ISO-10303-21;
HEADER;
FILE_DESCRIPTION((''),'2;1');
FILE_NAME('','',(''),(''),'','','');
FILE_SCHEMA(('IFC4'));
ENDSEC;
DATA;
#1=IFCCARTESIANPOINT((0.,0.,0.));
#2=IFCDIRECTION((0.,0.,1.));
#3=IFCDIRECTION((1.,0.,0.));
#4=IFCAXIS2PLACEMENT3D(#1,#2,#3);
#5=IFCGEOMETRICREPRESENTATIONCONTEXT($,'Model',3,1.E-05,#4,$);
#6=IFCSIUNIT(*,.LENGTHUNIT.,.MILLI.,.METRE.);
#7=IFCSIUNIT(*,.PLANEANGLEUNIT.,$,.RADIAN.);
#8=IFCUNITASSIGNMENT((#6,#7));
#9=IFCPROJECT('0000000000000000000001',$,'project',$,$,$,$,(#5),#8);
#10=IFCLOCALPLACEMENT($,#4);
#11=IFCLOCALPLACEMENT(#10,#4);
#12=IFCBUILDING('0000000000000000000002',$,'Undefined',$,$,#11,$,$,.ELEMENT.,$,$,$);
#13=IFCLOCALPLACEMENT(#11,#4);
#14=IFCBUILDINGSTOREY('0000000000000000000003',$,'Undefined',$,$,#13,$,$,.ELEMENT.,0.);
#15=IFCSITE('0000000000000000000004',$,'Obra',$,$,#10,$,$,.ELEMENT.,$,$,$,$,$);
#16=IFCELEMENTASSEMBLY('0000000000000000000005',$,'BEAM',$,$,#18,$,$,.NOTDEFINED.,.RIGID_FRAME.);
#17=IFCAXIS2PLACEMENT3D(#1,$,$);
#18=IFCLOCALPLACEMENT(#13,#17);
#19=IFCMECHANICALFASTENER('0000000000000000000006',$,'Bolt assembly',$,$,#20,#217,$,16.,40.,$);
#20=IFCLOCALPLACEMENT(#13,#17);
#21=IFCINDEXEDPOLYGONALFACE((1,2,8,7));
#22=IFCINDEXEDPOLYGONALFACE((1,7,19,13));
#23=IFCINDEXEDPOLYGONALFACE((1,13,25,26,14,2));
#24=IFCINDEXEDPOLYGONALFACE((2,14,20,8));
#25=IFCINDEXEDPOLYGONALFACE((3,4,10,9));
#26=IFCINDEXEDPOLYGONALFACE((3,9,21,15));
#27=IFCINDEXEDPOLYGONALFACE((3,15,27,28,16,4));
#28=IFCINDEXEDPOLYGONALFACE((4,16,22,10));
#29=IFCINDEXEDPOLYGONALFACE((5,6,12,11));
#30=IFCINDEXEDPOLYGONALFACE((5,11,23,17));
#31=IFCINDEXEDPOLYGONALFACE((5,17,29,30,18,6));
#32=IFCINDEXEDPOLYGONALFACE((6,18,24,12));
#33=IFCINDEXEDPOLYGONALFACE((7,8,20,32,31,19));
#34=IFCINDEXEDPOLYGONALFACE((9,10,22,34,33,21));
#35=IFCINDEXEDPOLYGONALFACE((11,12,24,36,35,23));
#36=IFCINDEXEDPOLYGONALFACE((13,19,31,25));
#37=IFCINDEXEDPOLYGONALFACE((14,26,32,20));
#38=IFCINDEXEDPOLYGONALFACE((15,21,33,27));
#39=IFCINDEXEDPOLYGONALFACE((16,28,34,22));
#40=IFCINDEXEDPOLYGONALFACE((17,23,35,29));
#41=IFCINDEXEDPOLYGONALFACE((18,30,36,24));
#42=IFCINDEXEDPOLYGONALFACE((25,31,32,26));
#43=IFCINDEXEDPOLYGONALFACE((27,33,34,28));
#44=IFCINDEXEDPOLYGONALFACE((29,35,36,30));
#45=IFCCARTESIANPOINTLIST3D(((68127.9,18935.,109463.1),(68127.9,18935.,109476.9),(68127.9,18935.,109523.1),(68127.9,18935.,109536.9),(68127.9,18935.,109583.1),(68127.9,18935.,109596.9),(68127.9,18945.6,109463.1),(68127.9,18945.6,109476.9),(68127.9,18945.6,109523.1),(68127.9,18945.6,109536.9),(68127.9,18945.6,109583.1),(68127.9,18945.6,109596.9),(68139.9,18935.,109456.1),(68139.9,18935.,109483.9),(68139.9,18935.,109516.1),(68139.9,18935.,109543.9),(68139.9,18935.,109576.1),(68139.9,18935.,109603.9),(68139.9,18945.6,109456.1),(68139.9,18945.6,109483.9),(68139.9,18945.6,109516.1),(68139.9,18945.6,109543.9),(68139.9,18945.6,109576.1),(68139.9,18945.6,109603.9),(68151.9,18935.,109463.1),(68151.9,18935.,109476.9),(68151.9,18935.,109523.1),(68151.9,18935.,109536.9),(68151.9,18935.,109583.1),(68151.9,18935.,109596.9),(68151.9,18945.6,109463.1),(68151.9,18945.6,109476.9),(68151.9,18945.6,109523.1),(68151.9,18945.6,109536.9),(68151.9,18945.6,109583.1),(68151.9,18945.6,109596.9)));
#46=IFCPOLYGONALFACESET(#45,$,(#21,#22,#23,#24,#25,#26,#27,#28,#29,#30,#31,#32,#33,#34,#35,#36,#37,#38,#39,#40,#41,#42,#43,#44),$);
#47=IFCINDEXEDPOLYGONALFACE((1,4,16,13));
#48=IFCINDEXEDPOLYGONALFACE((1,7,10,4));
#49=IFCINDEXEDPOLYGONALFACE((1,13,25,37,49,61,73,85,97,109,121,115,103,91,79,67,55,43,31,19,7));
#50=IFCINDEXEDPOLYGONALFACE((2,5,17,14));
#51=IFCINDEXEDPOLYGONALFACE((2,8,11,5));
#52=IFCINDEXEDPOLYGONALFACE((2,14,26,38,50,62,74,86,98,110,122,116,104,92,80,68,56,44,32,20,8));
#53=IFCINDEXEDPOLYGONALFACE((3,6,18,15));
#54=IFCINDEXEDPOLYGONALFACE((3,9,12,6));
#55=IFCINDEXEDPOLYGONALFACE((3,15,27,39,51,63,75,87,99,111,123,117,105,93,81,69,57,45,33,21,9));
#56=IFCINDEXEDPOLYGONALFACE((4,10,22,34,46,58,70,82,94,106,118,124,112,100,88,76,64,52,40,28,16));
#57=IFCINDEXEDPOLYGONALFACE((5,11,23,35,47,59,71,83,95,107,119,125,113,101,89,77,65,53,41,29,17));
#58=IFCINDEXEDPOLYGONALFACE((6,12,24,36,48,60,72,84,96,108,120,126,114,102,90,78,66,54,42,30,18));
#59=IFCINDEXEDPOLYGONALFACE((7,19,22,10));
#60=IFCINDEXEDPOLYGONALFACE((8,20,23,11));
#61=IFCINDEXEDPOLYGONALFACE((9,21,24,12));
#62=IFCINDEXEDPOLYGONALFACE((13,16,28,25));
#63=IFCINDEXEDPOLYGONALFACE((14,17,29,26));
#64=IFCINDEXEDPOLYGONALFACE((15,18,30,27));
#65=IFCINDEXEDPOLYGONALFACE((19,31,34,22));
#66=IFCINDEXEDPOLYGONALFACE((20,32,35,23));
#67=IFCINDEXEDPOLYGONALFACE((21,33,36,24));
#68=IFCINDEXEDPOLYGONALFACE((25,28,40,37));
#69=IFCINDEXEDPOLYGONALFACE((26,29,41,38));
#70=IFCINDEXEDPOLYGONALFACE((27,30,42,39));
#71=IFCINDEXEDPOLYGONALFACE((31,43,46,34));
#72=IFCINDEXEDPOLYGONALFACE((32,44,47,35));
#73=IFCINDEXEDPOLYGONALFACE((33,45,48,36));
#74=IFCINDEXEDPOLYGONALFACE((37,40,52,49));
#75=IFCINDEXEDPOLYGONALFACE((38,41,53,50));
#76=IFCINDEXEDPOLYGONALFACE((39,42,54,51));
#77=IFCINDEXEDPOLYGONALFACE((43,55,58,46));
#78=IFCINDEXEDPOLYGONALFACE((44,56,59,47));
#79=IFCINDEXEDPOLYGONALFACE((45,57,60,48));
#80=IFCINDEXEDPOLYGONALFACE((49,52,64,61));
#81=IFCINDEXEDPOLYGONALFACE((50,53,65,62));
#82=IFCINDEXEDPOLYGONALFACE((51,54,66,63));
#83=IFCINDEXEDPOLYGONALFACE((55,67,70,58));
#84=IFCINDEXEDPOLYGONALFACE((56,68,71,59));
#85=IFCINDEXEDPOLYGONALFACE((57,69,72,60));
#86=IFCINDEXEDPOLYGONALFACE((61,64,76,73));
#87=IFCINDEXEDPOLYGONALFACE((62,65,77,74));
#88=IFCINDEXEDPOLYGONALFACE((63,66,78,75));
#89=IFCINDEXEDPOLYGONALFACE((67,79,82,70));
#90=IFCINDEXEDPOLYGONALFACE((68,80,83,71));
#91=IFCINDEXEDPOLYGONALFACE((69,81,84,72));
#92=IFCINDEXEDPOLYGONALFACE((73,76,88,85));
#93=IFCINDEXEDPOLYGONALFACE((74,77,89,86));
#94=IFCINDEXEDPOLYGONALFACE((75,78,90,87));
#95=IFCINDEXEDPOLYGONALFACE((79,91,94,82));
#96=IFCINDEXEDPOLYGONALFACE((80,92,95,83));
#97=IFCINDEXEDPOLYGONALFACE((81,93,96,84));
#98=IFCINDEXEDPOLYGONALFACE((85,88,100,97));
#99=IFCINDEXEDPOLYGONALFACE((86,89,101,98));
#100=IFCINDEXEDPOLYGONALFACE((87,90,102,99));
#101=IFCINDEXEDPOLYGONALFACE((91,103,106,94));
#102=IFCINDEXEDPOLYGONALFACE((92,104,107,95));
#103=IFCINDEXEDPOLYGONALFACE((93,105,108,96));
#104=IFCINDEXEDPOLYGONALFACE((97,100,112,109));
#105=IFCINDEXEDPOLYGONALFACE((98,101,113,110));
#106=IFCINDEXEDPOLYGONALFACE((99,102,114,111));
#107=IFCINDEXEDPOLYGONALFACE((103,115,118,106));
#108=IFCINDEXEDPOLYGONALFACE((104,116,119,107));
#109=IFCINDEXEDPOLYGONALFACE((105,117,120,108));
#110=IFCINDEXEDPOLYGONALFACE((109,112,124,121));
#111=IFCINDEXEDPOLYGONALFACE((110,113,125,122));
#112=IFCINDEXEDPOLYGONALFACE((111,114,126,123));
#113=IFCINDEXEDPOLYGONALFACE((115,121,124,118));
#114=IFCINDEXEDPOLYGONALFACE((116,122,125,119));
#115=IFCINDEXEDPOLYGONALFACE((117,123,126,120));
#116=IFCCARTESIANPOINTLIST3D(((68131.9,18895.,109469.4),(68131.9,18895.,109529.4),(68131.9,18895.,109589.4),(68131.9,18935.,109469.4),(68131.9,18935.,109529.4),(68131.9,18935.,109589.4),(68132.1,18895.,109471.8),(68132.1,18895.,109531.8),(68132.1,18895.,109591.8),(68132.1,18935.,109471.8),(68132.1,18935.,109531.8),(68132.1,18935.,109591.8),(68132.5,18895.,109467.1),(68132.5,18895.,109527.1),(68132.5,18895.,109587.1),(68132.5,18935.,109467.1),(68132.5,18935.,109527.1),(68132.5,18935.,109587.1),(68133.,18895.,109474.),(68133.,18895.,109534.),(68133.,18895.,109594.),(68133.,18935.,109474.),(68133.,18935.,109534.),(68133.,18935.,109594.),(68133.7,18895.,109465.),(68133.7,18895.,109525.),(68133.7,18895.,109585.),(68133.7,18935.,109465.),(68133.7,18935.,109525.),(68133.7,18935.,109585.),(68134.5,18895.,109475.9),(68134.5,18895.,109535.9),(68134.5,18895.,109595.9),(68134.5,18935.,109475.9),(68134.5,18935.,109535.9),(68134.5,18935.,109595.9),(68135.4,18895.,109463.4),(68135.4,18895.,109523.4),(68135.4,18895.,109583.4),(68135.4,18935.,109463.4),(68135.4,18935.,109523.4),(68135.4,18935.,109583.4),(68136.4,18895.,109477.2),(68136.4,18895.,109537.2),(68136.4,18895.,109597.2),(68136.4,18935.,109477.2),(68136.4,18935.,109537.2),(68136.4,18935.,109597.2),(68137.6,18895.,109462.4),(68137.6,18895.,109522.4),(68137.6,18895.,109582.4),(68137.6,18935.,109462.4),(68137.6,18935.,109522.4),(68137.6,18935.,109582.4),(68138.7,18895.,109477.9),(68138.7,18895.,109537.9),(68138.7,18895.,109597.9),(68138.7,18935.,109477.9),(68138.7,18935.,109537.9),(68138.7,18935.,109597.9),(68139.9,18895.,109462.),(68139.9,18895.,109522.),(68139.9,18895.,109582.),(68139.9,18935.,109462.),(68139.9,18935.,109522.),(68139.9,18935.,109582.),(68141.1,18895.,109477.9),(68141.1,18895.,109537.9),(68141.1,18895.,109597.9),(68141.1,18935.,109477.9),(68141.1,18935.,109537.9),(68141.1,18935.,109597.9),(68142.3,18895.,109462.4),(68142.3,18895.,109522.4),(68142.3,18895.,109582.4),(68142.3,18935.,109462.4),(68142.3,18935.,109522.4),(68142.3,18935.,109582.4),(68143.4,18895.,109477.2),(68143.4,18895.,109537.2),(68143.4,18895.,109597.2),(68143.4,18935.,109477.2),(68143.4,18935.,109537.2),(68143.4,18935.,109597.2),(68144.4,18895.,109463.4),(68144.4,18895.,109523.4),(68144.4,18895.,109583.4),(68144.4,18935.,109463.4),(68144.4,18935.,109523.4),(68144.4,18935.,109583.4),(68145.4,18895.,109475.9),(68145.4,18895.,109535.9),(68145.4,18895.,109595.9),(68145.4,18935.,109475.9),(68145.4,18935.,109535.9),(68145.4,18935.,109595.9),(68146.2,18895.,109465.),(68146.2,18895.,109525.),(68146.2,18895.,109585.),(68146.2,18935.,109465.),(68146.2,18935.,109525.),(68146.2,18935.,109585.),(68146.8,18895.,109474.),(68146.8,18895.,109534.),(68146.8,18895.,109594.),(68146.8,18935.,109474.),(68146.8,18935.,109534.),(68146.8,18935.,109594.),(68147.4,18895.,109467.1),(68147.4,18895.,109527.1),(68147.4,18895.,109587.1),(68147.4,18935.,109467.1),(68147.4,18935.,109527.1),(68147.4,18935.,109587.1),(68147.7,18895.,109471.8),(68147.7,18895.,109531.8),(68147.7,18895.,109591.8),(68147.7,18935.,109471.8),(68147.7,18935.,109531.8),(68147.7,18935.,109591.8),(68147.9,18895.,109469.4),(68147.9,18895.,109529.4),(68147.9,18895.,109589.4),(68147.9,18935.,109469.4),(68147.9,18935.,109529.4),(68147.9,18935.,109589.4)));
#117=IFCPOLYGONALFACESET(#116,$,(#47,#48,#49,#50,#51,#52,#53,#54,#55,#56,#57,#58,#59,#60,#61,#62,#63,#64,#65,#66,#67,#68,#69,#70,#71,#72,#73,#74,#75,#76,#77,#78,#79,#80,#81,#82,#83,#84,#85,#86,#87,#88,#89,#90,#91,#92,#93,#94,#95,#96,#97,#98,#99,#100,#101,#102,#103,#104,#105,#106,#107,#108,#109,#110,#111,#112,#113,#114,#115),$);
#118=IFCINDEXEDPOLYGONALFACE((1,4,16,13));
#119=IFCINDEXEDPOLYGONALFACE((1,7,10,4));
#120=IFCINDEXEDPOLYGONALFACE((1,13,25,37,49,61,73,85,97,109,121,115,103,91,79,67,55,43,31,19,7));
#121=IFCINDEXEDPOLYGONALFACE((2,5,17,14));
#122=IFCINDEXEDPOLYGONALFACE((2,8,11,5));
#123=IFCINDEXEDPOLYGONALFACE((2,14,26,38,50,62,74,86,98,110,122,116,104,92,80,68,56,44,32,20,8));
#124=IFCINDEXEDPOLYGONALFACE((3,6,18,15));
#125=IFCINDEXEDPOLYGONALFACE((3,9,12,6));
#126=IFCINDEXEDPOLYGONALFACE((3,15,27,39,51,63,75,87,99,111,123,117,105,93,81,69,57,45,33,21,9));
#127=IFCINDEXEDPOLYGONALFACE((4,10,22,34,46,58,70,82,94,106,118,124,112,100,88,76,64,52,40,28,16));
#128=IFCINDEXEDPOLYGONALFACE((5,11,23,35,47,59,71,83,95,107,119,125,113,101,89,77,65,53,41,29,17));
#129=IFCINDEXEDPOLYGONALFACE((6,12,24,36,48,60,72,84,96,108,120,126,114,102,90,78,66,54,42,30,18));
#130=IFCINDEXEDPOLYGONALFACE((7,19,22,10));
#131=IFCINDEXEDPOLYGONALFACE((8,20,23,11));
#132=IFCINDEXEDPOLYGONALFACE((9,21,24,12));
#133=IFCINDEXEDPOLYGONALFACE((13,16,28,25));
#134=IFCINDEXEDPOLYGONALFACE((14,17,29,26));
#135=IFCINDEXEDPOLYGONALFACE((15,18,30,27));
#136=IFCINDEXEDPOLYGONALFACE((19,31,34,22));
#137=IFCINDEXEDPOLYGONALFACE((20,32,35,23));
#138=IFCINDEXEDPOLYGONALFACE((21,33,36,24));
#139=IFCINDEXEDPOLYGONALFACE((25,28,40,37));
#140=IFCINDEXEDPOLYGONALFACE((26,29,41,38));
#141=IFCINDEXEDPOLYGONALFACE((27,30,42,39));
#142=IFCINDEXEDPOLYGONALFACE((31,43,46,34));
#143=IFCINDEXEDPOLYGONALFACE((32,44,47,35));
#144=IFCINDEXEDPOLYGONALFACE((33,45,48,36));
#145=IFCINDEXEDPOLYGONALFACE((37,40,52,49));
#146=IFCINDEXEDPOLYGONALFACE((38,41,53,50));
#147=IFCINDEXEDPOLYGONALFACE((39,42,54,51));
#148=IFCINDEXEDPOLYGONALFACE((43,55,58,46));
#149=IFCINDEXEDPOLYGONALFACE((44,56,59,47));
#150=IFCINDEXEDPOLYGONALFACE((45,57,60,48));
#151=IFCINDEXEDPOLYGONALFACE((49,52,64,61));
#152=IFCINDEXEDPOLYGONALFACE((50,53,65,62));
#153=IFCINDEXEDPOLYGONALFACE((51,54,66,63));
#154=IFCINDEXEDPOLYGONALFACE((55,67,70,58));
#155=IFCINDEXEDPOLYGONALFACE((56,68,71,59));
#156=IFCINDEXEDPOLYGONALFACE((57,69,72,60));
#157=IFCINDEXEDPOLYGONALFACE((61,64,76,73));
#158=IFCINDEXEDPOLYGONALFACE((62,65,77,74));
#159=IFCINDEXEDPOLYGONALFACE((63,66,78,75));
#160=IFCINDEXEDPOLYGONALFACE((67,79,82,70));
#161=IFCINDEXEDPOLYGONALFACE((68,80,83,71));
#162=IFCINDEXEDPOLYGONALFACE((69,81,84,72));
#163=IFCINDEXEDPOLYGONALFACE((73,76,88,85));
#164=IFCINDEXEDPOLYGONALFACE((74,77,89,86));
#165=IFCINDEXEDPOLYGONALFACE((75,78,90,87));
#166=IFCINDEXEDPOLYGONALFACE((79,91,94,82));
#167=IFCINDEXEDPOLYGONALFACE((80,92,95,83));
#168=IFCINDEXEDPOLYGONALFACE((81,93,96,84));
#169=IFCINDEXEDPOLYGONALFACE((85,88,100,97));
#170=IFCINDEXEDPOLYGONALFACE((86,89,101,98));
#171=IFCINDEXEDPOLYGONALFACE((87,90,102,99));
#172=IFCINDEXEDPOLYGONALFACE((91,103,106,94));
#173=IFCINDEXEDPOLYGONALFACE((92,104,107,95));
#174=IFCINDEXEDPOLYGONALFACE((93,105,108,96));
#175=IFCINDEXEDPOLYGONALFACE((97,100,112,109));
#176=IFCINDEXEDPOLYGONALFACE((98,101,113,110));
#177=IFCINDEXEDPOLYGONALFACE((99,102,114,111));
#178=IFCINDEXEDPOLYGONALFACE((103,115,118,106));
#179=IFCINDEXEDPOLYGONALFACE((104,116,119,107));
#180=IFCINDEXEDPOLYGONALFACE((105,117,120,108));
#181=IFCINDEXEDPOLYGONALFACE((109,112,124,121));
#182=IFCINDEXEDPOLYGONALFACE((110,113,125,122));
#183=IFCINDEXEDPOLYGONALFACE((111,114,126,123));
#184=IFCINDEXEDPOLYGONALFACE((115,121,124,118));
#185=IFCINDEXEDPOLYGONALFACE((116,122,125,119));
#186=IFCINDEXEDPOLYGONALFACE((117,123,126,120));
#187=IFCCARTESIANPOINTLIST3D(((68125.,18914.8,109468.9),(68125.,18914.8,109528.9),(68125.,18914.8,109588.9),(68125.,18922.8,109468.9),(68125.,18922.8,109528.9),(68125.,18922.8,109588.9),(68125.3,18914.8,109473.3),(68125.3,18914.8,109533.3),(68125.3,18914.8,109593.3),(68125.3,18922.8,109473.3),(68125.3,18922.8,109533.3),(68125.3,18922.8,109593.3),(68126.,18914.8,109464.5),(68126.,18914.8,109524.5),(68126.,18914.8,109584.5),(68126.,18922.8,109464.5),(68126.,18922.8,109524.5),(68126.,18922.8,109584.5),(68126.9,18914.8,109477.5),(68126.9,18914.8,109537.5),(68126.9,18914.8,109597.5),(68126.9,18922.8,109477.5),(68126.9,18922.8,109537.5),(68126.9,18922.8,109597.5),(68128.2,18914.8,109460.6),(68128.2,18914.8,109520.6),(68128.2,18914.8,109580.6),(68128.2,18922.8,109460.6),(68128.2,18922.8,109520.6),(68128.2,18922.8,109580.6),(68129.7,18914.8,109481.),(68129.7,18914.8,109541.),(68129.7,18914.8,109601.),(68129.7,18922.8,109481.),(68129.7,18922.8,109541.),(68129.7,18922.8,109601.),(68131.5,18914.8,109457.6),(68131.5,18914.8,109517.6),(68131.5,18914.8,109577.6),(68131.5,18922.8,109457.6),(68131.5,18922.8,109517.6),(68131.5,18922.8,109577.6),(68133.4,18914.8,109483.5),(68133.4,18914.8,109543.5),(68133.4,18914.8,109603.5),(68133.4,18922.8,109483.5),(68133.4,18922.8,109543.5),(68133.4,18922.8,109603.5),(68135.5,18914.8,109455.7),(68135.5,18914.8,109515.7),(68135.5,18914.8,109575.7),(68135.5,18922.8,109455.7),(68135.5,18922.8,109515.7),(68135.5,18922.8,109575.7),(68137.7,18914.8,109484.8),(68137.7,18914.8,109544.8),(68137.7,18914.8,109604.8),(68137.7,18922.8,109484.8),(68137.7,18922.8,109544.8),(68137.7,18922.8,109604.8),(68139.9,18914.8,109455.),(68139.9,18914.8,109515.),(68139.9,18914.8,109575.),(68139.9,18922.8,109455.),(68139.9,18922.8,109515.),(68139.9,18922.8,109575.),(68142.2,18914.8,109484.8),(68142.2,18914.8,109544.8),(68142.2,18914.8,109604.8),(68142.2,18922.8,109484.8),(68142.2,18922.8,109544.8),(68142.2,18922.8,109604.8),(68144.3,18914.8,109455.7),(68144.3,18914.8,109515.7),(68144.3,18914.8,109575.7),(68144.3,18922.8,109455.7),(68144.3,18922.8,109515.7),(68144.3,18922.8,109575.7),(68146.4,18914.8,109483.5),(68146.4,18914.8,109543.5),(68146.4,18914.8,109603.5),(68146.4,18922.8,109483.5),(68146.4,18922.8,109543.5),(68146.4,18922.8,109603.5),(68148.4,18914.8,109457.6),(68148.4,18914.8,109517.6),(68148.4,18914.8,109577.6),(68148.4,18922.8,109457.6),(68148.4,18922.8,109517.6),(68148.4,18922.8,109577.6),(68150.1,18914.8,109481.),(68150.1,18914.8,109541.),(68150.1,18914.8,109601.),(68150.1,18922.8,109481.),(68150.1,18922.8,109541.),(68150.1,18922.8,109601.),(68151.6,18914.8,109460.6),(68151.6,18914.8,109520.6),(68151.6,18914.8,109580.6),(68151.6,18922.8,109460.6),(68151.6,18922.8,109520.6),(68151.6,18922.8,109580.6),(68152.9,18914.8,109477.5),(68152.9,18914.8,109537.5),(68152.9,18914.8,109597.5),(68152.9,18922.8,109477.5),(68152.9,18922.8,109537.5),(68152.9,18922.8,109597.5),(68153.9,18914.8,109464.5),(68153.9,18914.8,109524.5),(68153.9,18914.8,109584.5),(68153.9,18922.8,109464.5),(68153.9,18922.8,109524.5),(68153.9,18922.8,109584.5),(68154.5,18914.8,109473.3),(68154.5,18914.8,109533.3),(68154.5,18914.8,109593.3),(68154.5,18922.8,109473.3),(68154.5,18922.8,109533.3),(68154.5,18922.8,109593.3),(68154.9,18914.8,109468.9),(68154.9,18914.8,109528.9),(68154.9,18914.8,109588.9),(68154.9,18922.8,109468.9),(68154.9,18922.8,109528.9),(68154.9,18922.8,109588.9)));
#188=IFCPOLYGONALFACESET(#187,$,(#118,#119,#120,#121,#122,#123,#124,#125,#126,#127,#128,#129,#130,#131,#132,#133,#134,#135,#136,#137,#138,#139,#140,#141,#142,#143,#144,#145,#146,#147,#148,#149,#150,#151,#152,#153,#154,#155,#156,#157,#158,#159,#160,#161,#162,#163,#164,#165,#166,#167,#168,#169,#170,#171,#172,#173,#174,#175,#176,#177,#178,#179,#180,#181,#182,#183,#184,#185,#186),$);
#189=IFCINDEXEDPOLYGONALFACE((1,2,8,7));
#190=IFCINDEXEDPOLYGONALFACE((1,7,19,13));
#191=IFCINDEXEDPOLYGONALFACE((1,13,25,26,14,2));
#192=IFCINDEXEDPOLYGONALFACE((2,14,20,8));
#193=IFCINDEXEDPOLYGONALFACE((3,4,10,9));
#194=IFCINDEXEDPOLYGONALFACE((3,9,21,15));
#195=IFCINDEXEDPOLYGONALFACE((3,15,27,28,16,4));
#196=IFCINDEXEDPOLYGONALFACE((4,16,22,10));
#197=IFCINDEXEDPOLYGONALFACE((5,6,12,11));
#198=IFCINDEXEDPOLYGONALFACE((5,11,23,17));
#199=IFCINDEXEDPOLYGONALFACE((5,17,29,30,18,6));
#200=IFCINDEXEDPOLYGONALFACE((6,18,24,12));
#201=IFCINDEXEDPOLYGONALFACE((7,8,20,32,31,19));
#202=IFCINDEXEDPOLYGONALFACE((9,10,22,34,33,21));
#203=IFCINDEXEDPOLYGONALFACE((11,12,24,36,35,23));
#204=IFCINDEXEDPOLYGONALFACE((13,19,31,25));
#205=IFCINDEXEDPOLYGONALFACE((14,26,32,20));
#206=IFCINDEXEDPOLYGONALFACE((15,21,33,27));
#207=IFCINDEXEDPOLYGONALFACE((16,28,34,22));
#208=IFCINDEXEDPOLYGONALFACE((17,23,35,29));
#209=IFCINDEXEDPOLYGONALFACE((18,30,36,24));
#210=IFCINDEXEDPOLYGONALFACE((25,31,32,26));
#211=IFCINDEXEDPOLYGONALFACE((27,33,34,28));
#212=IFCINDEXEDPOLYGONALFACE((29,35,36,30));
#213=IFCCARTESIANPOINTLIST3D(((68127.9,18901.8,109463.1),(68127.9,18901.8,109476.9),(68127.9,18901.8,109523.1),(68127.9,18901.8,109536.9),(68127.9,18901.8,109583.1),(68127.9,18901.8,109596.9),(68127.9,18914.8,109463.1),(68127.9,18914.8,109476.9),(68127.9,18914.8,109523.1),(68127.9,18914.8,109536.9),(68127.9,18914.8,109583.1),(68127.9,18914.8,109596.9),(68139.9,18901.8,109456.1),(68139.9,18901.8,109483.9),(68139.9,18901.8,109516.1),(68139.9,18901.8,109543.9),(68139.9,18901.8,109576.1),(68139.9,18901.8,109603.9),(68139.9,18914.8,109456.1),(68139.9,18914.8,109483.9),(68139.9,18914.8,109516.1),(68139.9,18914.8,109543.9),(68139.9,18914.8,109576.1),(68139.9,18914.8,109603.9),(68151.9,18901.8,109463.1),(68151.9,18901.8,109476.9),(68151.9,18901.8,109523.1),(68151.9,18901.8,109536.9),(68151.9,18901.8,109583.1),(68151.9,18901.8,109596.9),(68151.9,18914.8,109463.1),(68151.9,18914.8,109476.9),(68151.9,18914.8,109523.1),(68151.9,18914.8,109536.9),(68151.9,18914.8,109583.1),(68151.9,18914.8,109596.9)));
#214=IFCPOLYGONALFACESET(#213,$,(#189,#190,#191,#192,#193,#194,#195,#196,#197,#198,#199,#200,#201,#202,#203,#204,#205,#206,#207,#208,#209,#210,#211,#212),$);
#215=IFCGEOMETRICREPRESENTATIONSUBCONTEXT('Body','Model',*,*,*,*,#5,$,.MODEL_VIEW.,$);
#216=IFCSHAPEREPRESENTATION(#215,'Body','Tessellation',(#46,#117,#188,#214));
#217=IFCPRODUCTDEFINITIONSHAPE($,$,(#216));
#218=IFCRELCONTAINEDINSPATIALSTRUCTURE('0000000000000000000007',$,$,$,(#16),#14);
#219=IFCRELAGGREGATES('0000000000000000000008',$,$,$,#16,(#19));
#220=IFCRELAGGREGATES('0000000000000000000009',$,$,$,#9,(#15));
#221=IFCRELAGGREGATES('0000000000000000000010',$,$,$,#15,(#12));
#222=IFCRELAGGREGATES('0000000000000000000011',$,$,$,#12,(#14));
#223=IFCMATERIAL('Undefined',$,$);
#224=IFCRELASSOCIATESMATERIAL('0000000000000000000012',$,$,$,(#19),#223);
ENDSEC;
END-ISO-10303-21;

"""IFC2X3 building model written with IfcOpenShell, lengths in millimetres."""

from ifc_helpers import new_model, si_unit, frame, origin_with_axes, origin_2d_with_axis, place, context, subcontext, project, spatial, polyline, circle, outline, extrude, source, transform, mapped, material, element, aggregate, save


model = new_model("IFC2X3")

# Units and contexts
model_context = context("Model", 3, precision=1e-05, world=origin_with_axes())
body_context = subcontext(model_context, "Body", "Model", "MODEL_VIEW")
ifc_project = project(units=[si_unit("LENGTHUNIT", "METRE", prefix="MILLI"), si_unit("PLANEANGLEUNIT", "RADIAN")], contexts=[model_context])

# Site, building, storey
site_placement = place(None, origin_with_axes())
site = spatial("IfcSite", under=ifc_project, at=site_placement, Name="Obra", CompositionType="ELEMENT")
building_placement = place(site_placement, origin_with_axes())
building = spatial("IfcBuilding", under=site, at=building_placement, Name="Undefined", CompositionType="ELEMENT")
storey_placement = place(building_placement, origin_with_axes())
storey = spatial("IfcBuildingStorey", under=building, at=storey_placement, Name="Undefined", CompositionType="ELEMENT", Elevation=0.0)

# Shared definitions
ifc_material_1 = material(Name="Undefined")

# Element assembly, mechanical fastener
assembly_1_placement = place(storey_placement, origin_with_axes())
assembly_1 = element("IfcElementAssembly", 1, at=assembly_1_placement, inside=storey, Name="BEAM", AssemblyPlace="NOTDEFINED", PredefinedType="RIGID_FRAME")
shared_shape_1 = source(origin_with_axes(), body_context, "Body", "SweptSolid", [
    extrude(outline(polyline([(13.9, 0.0), (6.9, 12.0), (-6.9, 12.0), (-13.9, 0.0), (-6.9, -12.0), (6.9, -12.0), (13.9, 0.0)])), frame((0.0, -19.7, 0.0), z_axis=(0.0, 1.0, 0.0), x_axis=(1.0, 0.0, 0.0)), (0.0, 0.0, 1.0), 10.6),
    extrude(circle(Radius=8.0, at=origin_2d_with_axis()), frame((0.0, -9.1, 0.0), z_axis=(0.0, 1.0, 0.0), x_axis=(1.0, 0.0, 0.0)), (0.0, 0.0, 1.0), 40.0),
    extrude(circle(Radius=15.0, at=origin_2d_with_axis()), frame((0.0, 3.1, 0.0), z_axis=(0.0, 1.0, 0.0), x_axis=(1.0, 0.0, 0.0)), (0.0, 0.0, 1.0), 8.0),
    extrude(outline(polyline([(13.9, 0.0), (6.9, 12.0), (-6.9, 12.0), (-13.9, 0.0), (-6.9, -12.0), (6.9, -12.0), (13.9, 0.0)])), frame((0.0, 11.1, 0.0), z_axis=(0.0, 1.0, 0.0), x_axis=(1.0, 0.0, 0.0)), (0.0, 0.0, 1.0), 13.0),
])
mechanical_fastener_1_placement = place(assembly_1_placement, frame((68189.9, 18925.9, 109650.0), z_axis=(-1.0, 0.000126, 0.0), x_axis=(0.0, 0.0, -1.0)))
mechanical_fastener_1 = element("IfcMechanicalFastener", 2, at=mechanical_fastener_1_placement, material=ifc_material_1, Name="Bolt assembly", NominalDiameter=16.0, NominalLength=40.0, context=body_context, shape_type="MappedRepresentation", body=[
    mapped(shared_shape_1, transform((60.0, 0.0, 50.0))),
    mapped(shared_shape_1, transform((120.0, 0.0, 50.0))),
    mapped(shared_shape_1, transform((180.0, 0.0, 50.0))),
])
aggregate(assembly_1, [mechanical_fastener_1])

save(model, "model.ifc")
